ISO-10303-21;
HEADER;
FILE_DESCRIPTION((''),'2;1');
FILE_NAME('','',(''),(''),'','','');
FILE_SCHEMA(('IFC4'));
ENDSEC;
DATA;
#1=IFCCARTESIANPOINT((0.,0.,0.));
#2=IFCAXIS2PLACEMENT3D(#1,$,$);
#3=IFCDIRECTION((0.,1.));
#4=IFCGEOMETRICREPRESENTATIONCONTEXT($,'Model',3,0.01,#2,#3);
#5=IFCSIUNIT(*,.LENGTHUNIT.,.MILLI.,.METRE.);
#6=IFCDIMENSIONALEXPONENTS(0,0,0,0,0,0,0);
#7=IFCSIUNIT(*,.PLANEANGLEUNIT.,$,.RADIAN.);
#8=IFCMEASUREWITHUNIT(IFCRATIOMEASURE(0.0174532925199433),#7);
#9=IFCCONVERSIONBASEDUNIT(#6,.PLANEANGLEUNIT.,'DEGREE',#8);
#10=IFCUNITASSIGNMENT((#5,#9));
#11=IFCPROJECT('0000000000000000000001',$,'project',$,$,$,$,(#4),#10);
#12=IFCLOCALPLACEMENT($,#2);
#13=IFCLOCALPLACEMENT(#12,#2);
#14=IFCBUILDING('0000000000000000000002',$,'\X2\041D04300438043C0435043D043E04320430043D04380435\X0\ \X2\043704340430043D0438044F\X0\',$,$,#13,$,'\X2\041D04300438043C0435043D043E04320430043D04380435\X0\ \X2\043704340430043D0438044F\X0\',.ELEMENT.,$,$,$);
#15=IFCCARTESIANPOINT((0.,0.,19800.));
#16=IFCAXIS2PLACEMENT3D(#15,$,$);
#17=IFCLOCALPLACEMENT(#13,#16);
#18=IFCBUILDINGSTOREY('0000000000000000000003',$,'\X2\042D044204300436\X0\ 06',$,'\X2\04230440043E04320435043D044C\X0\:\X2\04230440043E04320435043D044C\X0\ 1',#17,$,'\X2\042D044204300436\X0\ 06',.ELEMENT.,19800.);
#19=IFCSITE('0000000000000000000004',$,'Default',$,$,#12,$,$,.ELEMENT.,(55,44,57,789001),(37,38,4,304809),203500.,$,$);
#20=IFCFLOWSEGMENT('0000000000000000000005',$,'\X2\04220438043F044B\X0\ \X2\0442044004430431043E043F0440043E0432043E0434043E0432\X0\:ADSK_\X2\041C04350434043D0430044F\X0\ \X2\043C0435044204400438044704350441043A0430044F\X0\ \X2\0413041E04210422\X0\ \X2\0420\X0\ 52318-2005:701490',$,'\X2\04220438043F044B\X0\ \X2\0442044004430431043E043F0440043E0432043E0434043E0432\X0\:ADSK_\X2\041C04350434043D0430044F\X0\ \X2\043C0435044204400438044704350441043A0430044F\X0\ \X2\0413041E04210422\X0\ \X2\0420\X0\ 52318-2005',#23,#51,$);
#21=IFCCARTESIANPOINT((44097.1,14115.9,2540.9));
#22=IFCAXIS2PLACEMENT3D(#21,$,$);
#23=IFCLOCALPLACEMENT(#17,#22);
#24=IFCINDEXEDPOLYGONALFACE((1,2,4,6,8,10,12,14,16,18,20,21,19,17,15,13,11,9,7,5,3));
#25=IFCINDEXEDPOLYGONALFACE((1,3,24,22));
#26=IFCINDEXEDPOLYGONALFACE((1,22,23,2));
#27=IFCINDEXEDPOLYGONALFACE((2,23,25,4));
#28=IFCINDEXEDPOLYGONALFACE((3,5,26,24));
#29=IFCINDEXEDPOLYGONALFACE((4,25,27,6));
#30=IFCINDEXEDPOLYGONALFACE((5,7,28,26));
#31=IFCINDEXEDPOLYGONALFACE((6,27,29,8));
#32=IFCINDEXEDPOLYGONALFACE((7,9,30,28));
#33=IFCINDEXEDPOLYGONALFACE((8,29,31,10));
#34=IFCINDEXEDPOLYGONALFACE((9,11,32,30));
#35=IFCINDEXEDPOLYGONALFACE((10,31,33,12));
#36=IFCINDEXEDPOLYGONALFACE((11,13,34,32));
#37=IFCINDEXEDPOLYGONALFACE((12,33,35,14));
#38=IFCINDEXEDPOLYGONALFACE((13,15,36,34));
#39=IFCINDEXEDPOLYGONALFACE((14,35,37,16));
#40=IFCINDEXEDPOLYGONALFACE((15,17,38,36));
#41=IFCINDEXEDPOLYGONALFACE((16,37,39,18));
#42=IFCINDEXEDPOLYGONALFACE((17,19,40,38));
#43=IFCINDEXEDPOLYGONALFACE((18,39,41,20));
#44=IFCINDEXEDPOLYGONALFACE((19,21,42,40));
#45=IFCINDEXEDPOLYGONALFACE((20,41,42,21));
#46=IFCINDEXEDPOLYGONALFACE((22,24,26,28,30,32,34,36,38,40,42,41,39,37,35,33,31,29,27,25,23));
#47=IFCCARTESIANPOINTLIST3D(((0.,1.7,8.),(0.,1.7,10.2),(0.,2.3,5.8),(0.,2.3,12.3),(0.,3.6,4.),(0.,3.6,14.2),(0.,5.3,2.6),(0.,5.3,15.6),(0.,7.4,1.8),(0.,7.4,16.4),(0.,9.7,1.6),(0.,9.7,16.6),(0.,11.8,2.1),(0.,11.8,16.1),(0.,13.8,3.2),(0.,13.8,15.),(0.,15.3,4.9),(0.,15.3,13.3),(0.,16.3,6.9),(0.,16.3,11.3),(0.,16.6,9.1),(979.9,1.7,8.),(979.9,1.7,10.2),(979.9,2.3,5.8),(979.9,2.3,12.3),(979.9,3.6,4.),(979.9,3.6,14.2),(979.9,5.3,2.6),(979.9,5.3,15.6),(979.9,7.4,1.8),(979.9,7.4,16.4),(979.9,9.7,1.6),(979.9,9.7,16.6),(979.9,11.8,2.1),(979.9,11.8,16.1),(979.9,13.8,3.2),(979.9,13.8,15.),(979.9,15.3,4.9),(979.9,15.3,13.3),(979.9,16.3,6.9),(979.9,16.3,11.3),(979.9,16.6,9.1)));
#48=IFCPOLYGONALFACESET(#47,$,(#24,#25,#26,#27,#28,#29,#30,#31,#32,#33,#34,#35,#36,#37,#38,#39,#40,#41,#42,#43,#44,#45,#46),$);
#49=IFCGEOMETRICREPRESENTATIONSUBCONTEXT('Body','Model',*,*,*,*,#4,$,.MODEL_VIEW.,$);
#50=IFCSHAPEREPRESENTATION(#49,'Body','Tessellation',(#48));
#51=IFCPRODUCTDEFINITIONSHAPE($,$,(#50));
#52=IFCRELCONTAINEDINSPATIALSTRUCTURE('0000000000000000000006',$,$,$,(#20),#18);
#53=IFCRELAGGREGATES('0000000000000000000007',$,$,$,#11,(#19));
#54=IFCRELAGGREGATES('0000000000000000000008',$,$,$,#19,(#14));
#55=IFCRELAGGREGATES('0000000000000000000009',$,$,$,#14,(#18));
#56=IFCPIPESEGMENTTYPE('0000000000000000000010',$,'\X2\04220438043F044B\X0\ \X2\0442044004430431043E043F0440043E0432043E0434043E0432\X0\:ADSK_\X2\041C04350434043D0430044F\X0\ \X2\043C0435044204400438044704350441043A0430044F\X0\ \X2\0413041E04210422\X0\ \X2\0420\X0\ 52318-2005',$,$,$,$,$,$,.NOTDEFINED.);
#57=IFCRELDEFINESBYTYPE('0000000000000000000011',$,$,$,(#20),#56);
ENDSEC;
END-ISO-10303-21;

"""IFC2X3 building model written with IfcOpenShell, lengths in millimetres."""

from ifc_helpers import new_model, entity, si_unit, converted_unit, direction, frame, frame_2d, origin, place, context, subcontext, project, spatial, circle, extrude, type_object, element, save


model = new_model("IFC2X3")

# Units and contexts
model_context = context("Model", 3, precision=0.01, world=origin(), true_north=direction((0.0, 1.0)))
body_context = subcontext(model_context, "Body", "Model", "MODEL_VIEW")
ifc_project = project(units=[si_unit("LENGTHUNIT", "METRE", prefix="MILLI"), converted_unit("PLANEANGLEUNIT", "DEGREE", entity("IfcRatioMeasure", 0.0174532925199433), si_unit("PLANEANGLEUNIT", "RADIAN"), dimensions=[0, 0, 0, 0, 0, 0, 0])], contexts=[model_context])

# Site, building, storey
site_placement = place(None, frame((0.0, 0.0, 0.0)))
site = spatial("IfcSite", under=ifc_project, at=site_placement, Name="Default", CompositionType="ELEMENT", RefLatitude=(55, 44, 57, 789001), RefLongitude=(37, 38, 4, 304809), RefElevation=203500.0)
building_placement = place(site_placement, origin())
building = spatial("IfcBuilding", under=site, at=building_placement, Name="Наименование здания", LongName="Наименование здания", CompositionType="ELEMENT")
storey_placement = place(building_placement, frame((0.0, 0.0, 19800.0)))
storey = spatial("IfcBuildingStorey", under=building, at=storey_placement, Name="Этаж 06", ObjectType="Уровень:Уровень 1", LongName="Этаж 06", CompositionType="ELEMENT", Elevation=19800.0)

# Flow segment
pipe_segment_type = type_object("IfcPipeSegmentType", Name="Типы трубопроводов:ADSK_Медная метрическая ГОСТ Р 52318-2005", PredefinedType="NOTDEFINED")
flow_segment_1_placement = place(storey_placement, frame((44097.1, 14115.9, 2540.9)))
element("IfcFlowSegment", 1, at=flow_segment_1_placement, inside=storey, type_object=pipe_segment_type, Name="Типы трубопроводов:ADSK_Медная метрическая ГОСТ Р 52318-2005:701490", ObjectType="Типы трубопроводов:ADSK_Медная метрическая ГОСТ Р 52318-2005", context=body_context, shape_type="SweptSolid", body=[
    extrude(circle(Radius=7.5, at=frame_2d((0.0, 0.0), x_axis=(1.0, 0.0))), frame((0.0, 9.1, 9.1), z_axis=(1.0, 0.0, 0.0), x_axis=(0.0, 1.0, 0.0)), (0.0, 0.0, 1.0), 979.9),
])

save(model, "model.ifc")
